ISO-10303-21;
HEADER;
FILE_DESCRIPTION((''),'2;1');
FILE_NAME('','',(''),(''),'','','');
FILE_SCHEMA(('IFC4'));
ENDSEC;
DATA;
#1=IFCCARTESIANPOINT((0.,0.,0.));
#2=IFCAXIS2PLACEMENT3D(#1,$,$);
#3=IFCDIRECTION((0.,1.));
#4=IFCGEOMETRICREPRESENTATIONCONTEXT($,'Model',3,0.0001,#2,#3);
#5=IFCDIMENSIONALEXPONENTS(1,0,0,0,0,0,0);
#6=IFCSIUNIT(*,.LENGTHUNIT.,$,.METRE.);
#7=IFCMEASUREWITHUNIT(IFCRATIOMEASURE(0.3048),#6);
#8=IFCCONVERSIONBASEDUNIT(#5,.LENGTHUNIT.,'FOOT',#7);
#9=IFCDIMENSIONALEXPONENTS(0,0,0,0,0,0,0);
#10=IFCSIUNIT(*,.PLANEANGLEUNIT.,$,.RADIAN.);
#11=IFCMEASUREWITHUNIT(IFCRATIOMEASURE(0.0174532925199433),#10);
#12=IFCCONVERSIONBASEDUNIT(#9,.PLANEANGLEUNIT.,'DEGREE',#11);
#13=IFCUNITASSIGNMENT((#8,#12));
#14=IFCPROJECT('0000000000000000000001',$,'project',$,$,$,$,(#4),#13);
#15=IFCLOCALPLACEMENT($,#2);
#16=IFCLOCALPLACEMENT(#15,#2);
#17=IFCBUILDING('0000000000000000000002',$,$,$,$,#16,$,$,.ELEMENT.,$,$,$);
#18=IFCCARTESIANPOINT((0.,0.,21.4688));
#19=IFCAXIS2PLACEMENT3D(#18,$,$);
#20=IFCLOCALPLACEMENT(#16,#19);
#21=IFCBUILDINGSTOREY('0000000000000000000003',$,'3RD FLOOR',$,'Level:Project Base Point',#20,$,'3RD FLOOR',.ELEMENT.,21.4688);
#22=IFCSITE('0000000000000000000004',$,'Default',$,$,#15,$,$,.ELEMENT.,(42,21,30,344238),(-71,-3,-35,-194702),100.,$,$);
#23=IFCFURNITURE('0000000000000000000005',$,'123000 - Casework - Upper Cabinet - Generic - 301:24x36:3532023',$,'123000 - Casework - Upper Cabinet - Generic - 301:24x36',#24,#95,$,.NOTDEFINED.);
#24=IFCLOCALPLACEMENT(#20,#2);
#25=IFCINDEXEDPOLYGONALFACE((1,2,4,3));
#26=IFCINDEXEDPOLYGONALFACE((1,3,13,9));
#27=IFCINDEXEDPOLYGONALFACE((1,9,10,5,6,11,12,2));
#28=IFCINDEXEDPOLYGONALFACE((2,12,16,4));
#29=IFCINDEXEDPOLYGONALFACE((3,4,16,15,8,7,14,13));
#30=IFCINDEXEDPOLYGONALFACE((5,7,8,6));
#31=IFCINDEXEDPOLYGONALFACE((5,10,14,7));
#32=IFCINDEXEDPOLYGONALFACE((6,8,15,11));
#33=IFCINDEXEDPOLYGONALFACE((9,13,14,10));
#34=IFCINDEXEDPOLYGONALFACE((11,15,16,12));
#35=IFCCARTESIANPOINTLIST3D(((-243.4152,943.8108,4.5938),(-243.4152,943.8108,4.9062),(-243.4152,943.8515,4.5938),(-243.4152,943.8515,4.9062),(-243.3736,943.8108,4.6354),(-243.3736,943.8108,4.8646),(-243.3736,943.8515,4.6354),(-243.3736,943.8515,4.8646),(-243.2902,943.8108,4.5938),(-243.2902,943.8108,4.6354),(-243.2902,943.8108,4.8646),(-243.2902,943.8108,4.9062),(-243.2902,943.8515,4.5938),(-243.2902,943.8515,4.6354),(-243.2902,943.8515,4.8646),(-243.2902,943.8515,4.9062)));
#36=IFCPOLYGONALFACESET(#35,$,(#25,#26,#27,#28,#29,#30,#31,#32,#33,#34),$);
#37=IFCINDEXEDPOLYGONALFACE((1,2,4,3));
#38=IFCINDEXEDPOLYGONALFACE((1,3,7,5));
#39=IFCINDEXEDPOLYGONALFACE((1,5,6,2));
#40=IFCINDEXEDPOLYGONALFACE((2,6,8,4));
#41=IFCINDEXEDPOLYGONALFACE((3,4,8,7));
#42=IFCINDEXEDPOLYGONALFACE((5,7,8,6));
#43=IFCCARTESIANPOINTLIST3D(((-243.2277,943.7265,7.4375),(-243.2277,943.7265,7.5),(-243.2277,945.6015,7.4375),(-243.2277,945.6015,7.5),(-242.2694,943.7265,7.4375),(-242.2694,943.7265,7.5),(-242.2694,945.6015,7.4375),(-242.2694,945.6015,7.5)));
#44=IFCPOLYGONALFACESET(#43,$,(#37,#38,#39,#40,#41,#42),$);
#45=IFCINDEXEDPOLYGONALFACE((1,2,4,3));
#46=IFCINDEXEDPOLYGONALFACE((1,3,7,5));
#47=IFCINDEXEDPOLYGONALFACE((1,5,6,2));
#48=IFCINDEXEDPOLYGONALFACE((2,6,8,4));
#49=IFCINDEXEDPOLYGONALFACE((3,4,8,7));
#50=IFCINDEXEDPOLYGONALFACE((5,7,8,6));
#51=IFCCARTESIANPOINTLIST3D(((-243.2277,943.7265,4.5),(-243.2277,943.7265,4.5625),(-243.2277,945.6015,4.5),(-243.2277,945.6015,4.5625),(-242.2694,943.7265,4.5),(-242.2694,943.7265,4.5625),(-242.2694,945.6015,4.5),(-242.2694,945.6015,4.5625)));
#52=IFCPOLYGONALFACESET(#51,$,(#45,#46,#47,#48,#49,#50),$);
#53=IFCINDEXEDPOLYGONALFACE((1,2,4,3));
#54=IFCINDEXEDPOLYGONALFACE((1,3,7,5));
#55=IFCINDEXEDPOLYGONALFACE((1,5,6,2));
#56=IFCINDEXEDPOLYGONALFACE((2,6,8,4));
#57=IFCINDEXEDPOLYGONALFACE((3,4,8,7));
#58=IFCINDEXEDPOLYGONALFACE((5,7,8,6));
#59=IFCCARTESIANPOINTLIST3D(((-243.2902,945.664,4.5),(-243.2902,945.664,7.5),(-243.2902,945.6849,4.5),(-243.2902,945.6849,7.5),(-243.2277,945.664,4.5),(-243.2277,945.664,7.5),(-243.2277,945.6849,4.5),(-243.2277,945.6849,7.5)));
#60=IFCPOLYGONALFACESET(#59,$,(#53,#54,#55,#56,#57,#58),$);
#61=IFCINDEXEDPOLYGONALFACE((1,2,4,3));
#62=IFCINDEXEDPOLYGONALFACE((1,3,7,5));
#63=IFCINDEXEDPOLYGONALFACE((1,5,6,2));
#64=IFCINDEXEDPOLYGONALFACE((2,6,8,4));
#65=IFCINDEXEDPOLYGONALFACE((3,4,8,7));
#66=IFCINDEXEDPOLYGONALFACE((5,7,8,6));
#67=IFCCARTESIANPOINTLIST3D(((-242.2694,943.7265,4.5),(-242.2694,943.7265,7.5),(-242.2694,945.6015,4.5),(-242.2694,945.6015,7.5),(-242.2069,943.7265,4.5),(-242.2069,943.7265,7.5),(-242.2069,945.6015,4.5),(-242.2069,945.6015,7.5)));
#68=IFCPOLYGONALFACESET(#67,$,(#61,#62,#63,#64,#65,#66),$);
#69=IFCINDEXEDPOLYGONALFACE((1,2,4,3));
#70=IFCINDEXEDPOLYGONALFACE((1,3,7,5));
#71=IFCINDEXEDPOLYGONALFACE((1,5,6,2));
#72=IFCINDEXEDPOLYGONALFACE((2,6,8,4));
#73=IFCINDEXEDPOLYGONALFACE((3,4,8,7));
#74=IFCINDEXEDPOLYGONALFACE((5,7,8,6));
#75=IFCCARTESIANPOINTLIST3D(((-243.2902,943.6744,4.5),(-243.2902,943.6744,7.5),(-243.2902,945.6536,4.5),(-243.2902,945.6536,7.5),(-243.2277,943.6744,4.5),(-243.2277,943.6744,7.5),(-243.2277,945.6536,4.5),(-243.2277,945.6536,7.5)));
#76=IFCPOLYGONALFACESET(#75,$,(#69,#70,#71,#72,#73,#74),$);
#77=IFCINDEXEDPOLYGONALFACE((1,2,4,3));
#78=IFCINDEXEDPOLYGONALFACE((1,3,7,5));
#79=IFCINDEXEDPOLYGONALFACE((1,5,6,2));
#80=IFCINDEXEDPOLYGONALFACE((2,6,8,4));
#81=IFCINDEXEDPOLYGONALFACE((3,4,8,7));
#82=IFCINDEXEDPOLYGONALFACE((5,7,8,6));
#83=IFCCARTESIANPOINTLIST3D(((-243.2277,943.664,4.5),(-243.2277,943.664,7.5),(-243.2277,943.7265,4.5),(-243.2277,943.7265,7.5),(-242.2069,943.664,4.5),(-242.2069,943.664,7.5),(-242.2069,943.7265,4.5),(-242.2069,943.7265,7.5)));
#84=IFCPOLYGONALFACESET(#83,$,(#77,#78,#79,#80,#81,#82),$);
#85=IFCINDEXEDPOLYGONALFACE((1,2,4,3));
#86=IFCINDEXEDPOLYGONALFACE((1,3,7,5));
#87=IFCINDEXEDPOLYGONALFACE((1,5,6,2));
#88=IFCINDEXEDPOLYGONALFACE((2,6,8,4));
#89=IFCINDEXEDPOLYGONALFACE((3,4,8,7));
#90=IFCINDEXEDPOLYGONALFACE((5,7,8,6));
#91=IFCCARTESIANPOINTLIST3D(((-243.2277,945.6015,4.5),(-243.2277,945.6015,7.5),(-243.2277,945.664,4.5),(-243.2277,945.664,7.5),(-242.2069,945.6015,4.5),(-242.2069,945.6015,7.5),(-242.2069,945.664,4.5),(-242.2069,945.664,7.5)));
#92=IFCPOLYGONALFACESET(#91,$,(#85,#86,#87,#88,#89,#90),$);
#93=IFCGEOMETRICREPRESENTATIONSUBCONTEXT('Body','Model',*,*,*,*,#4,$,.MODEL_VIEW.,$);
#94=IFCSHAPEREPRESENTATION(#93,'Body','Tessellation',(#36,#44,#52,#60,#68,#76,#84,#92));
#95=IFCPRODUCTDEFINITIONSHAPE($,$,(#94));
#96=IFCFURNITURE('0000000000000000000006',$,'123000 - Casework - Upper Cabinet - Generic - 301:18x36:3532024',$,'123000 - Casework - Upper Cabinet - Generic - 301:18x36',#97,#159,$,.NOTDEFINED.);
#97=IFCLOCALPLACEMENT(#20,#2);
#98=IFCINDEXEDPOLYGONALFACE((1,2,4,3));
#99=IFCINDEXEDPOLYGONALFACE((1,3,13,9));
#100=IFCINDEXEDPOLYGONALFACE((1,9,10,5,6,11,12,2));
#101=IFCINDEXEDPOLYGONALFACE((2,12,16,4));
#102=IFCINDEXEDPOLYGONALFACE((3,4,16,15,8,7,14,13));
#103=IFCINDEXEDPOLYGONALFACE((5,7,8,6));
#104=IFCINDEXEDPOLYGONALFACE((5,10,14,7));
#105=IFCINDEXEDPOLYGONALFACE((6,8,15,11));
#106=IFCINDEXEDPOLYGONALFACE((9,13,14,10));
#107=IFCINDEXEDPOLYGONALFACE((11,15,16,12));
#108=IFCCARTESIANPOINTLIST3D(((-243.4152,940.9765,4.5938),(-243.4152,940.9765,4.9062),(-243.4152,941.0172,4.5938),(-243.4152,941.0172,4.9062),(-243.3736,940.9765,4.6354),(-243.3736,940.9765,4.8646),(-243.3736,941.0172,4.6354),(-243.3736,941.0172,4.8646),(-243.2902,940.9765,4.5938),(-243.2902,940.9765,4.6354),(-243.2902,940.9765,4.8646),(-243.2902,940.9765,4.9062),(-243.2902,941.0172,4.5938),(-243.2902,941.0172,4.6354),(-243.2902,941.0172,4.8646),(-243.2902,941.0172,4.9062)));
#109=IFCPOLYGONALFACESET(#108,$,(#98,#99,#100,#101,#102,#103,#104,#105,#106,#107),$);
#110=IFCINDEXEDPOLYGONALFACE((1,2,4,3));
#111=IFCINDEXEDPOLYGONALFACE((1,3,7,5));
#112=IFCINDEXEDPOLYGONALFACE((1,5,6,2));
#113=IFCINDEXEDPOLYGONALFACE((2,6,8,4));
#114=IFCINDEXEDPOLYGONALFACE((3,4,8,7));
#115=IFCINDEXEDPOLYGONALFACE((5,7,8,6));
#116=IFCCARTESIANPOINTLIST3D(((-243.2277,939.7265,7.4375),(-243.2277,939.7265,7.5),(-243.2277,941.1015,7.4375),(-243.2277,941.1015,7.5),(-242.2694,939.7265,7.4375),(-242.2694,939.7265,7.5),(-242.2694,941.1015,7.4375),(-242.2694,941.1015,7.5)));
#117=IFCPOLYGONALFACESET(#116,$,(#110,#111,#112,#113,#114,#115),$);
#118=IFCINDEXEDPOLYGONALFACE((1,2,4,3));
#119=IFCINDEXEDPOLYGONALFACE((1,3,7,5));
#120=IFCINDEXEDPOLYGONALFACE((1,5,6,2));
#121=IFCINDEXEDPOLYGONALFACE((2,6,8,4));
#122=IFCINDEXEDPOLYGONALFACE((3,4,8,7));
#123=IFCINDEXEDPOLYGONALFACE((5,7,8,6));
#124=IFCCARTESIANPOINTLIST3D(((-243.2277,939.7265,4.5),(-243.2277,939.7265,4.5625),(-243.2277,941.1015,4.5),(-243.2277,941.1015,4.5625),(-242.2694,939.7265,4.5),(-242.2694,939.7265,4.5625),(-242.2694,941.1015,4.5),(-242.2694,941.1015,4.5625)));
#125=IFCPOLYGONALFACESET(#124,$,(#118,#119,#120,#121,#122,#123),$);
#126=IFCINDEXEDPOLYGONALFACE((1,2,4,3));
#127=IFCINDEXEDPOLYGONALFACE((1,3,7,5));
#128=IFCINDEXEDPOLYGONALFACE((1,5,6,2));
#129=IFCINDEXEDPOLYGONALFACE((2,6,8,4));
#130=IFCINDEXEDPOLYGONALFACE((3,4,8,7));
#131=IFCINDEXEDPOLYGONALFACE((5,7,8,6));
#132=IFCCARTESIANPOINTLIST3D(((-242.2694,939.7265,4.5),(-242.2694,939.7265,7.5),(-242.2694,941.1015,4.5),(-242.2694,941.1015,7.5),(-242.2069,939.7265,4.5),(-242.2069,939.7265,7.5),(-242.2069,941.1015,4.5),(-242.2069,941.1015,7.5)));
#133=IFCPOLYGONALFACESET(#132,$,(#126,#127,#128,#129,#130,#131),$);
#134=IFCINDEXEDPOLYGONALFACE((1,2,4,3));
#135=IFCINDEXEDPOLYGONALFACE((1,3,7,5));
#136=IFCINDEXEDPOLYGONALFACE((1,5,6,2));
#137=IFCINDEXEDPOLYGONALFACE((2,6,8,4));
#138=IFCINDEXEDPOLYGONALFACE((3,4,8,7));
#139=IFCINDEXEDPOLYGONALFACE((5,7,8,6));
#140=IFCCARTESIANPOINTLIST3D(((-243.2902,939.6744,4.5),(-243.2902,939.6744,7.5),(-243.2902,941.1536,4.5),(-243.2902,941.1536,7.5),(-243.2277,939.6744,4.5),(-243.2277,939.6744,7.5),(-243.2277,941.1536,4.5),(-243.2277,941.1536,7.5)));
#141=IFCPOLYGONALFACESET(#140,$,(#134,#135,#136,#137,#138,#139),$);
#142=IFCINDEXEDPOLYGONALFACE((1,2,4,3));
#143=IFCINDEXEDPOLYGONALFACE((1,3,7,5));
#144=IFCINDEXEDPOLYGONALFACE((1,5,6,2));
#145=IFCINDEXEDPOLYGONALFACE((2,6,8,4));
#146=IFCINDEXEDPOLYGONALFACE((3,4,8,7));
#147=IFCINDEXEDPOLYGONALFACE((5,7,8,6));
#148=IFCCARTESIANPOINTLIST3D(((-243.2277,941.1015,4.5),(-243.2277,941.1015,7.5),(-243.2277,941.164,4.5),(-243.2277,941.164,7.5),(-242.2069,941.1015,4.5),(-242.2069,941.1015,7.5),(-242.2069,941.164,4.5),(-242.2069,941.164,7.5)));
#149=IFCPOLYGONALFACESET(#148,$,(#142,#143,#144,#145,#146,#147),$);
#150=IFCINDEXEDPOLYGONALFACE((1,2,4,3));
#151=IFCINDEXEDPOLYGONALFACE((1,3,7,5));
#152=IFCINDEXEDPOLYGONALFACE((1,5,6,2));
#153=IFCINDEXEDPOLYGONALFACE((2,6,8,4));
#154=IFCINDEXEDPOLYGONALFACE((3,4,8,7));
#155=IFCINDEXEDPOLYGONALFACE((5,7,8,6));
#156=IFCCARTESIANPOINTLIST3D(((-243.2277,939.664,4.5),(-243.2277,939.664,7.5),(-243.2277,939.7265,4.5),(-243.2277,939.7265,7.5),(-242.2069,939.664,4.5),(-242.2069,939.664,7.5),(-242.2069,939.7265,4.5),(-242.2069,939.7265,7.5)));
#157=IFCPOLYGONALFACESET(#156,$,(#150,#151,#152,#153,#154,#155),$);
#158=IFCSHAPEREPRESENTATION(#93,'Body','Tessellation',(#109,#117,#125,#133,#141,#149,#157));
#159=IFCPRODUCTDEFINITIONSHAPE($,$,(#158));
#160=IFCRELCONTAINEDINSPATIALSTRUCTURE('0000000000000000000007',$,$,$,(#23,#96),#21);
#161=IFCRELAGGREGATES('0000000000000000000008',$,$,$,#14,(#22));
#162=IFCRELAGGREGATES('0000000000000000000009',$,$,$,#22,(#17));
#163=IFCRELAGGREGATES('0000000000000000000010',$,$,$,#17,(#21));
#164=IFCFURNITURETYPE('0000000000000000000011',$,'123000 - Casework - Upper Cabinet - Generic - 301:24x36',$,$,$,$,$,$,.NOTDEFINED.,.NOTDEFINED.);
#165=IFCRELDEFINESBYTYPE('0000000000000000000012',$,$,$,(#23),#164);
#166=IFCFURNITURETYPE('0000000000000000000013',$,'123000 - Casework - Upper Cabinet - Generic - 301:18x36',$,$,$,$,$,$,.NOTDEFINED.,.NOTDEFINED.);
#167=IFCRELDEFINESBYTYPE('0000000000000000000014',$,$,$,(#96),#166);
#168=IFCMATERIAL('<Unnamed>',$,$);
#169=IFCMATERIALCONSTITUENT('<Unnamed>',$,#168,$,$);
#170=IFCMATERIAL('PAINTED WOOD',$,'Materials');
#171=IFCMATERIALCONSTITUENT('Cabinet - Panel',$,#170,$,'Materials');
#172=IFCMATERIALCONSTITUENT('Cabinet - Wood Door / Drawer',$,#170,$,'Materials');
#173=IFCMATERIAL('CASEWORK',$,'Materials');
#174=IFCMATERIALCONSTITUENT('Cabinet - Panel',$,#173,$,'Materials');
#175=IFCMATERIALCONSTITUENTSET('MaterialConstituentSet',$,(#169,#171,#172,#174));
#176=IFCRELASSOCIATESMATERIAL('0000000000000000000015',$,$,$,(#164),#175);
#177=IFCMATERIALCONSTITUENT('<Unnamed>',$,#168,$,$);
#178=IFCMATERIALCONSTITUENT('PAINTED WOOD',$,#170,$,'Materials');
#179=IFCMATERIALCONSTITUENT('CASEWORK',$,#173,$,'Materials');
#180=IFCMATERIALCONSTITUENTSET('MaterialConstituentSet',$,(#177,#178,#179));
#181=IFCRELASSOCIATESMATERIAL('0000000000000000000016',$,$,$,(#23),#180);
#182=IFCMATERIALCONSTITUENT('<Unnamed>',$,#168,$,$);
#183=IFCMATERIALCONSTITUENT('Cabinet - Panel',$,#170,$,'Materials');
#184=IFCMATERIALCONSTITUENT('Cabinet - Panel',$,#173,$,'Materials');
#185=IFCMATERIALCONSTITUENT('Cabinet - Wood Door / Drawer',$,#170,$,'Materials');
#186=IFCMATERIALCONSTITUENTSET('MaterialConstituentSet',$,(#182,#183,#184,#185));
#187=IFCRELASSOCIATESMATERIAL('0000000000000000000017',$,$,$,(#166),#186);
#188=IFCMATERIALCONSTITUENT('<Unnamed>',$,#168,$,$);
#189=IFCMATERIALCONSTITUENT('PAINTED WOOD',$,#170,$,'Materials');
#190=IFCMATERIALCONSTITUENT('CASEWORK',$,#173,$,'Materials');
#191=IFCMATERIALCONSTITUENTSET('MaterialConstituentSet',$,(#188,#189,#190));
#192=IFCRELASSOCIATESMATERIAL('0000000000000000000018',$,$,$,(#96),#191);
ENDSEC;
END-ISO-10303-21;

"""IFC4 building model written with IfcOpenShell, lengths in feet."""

from ifc_helpers import new_model, entity, si_unit, converted_unit, direction, frame, frame_2d, origin, origin_2d_with_axis, place, context, subcontext, project, spatial, polyline, rectangle, outline, extrude, source, transform, mapped, material, constituent, constituent_set, type_object, type_shapes, element, save


model = new_model("IFC4")

# Units and contexts
model_context = context("Model", 3, precision=0.0001, world=origin(), true_north=direction((0.0, 1.0)))
body_context = subcontext(model_context, "Body", "Model", "MODEL_VIEW")
ifc_project = project(units=[converted_unit("LENGTHUNIT", "FOOT", entity("IfcRatioMeasure", 0.3048), si_unit("LENGTHUNIT", "METRE"), dimensions=[1, 0, 0, 0, 0, 0, 0]), converted_unit("PLANEANGLEUNIT", "DEGREE", entity("IfcRatioMeasure", 0.0174532925199433), si_unit("PLANEANGLEUNIT", "RADIAN"), dimensions=[0, 0, 0, 0, 0, 0, 0])], contexts=[model_context])

# Site, building, storey
site_placement = place(None, origin())
site = spatial("IfcSite", under=ifc_project, at=site_placement, Name="Default", CompositionType="ELEMENT", RefLatitude=(42, 21, 30, 344238), RefLongitude=(-71, -3, -35, -194702), RefElevation=100.0)
building_placement = place(site_placement, origin())
building = spatial("IfcBuilding", under=site, at=building_placement, CompositionType="ELEMENT")
storey_placement = place(building_placement, frame((0.0, 0.0, 21.4688)))
storey = spatial("IfcBuildingStorey", under=building, at=storey_placement, Name="3RD FLOOR", ObjectType="Level:Project Base Point", LongName="3RD FLOOR", CompositionType="ELEMENT", Elevation=21.4688)

# Furniture
ifc_material_1 = material(Name="CASEWORK", Category="Materials")
ifc_material_2 = material(Name="<Unnamed>")
ifc_material_3 = material(Name="PAINTED WOOD", Category="Materials")
ifc_constituent_1 = constituent(ifc_material_2, Name="<Unnamed>")
ifc_constituent_2 = constituent(ifc_material_3, Name="PAINTED WOOD", Category="Materials")
ifc_constituent_3 = constituent(ifc_material_1, Name="CASEWORK", Category="Materials")
ifc_constituent_set_1 = constituent_set(constituents=[ifc_constituent_1, ifc_constituent_2, ifc_constituent_3], Name="MaterialConstituentSet")
ifc_constituent_4 = constituent(ifc_material_2, Name="<Unnamed>")
ifc_constituent_5 = constituent(ifc_material_3, Name="Cabinet - Panel", Category="Materials")
ifc_constituent_6 = constituent(ifc_material_3, Name="Cabinet - Wood Door / Drawer", Category="Materials")
ifc_constituent_7 = constituent(ifc_material_1, Name="Cabinet - Panel", Category="Materials")
ifc_constituent_set_2 = constituent_set(constituents=[ifc_constituent_4, ifc_constituent_5, ifc_constituent_6, ifc_constituent_7], Name="MaterialConstituentSet")
furniture_type_1 = type_object("IfcFurnitureType", Name="123000 - Casework - Upper Cabinet - Generic - 301:24x36", AssemblyPlace="NOTDEFINED", PredefinedType="NOTDEFINED", material=ifc_constituent_set_2)
shared_shape_1 = source(origin(), body_context, "Body", "SweptSolid", [
    extrude(outline(polyline([(-0.0521, -0.1146), (-0.0521, -0.1562), (0.0729, -0.1562), (0.0729, 0.1562), (-0.0521, 0.1562), (-0.0521, 0.1146), (0.0313, 0.1146), (0.0313, -0.1146), (-0.0521, -0.1146)])), frame((0.1468, 1.1354, 0.25), z_axis=(-1.0, 0.0, 0.0), x_axis=(0.0, 1.0, 0.0)), (0.0, 0.0, -1.0), 0.0407),
    extrude(rectangle(XDim=0.9583, YDim=1.875, at=frame_2d((0.0, 0.0), x_axis=(1.0, 0.0))), frame((1.0, 0.5417, 2.9375), z_axis=(0.0, 0.0, 1.0), x_axis=(0.0, 1.0, 0.0)), (0.0, 0.0, 1.0), 0.0625),
    extrude(rectangle(XDim=0.9583, YDim=1.875, at=frame_2d((0.0, 0.0), x_axis=(1.0, 0.0))), frame((1.0, 0.5417, 0.0), z_axis=(0.0, 0.0, 1.0), x_axis=(0.0, 1.0, 0.0)), (0.0, 0.0, 1.0), 0.0625),
    extrude(rectangle(XDim=0.0208, YDim=0.0625, at=frame_2d((0.0, 0.0), x_axis=(1.0, 0.0))), frame((2.0104, 1.0521, 0.0)), (0.0, 0.0, 1.0), 3.0),
    extrude(rectangle(XDim=1.875, YDim=0.0625, at=origin_2d_with_axis()), frame((1.0, 0.0313, 0.0), z_axis=(0.0, 0.0, 1.0), x_axis=(-1.0, 0.0, 0.0)), (0.0, 0.0, 1.0), 3.0),
    extrude(rectangle(XDim=1.9792, YDim=0.0625, at=frame_2d((0.0, 0.0), x_axis=(1.0, 0.0))), frame((1.0, 1.0521, 0.0)), (0.0, 0.0, 1.0), 3.0),
    extrude(rectangle(XDim=1.0208, YDim=0.0625, at=origin_2d_with_axis()), frame((0.0312, 0.5104, 0.0), z_axis=(0.0, 0.0, 1.0), x_axis=(0.0, 1.0, 0.0)), (0.0, 0.0, 1.0), 3.0),
    extrude(rectangle(XDim=1.0208, YDim=0.0625, at=origin_2d_with_axis()), frame((1.9688, 0.5104, 0.0), z_axis=(0.0, 0.0, 1.0), x_axis=(0.0, 1.0, 0.0)), (0.0, 0.0, 1.0), 3.0),
])
type_shapes(furniture_type_1, [shared_shape_1])
furniture_1_placement = place(storey_placement, frame((-242.2069, 943.664, 4.5), z_axis=(0.0, 0.0, 1.0), x_axis=(0.0, 1.0, 0.0)))
element("IfcFurniture", 1, at=furniture_1_placement, inside=storey, type_object=furniture_type_1, material=ifc_constituent_set_1, Name="123000 - Casework - Upper Cabinet - Generic - 301:24x36:3532023", ObjectType="123000 - Casework - Upper Cabinet - Generic - 301:24x36", PredefinedType="NOTDEFINED", context=body_context, shape_type="MappedRepresentation", body=[
    mapped(shared_shape_1, transform((0.0, 0.0, 0.0), scale=1.0)),
])
ifc_constituent_8 = constituent(ifc_material_2, Name="<Unnamed>")
ifc_constituent_9 = constituent(ifc_material_3, Name="PAINTED WOOD", Category="Materials")
ifc_constituent_10 = constituent(ifc_material_1, Name="CASEWORK", Category="Materials")
ifc_constituent_set_3 = constituent_set(constituents=[ifc_constituent_8, ifc_constituent_9, ifc_constituent_10], Name="MaterialConstituentSet")
ifc_constituent_11 = constituent(ifc_material_2, Name="<Unnamed>")
ifc_constituent_12 = constituent(ifc_material_3, Name="Cabinet - Panel", Category="Materials")
ifc_constituent_13 = constituent(ifc_material_1, Name="Cabinet - Panel", Category="Materials")
ifc_constituent_14 = constituent(ifc_material_3, Name="Cabinet - Wood Door / Drawer", Category="Materials")
ifc_constituent_set_4 = constituent_set(constituents=[ifc_constituent_11, ifc_constituent_12, ifc_constituent_13, ifc_constituent_14], Name="MaterialConstituentSet")
furniture_type_2 = type_object("IfcFurnitureType", Name="123000 - Casework - Upper Cabinet - Generic - 301:18x36", AssemblyPlace="NOTDEFINED", PredefinedType="NOTDEFINED", material=ifc_constituent_set_4)
shared_shape_2 = source(origin(), body_context, "Body", "SweptSolid", [
    extrude(outline(polyline([(0.1146, -0.0521), (0.1562, -0.0521), (0.1562, 0.0729), (-0.1562, 0.0729), (-0.1562, -0.0521), (-0.1146, -0.0521), (-0.1146, 0.0313), (0.1146, 0.0313), (0.1146, -0.0521)])), frame((0.1468, 0.0729, 0.25), z_axis=(1.0, 0.0, 0.0), x_axis=(0.0, 0.0, 1.0)), (0.0, 0.0, 1.0), 0.0407),
    extrude(rectangle(XDim=1.375, YDim=0.9583, at=frame_2d((0.0, 0.0), x_axis=(1.0, 0.0))), frame((0.75, 0.6666, 2.9375), z_axis=(0.0, 0.0, 1.0), x_axis=(-1.0, 0.0, 0.0)), (0.0, 0.0, 1.0), 0.0625),
    extrude(rectangle(XDim=1.375, YDim=0.9583, at=frame_2d((0.0, 0.0), x_axis=(1.0, 0.0))), frame((0.75, 0.6666, 0.0), z_axis=(0.0, 0.0, 1.0), x_axis=(-1.0, 0.0, 0.0)), (0.0, 0.0, 1.0), 0.0625),
    extrude(rectangle(XDim=0.0625, YDim=1.375, at=origin_2d_with_axis()), frame((0.75, 1.177, 0.0), z_axis=(0.0, 0.0, 1.0), x_axis=(0.0, 1.0, 0.0)), (0.0, 0.0, 1.0), 3.0),
    extrude(rectangle(XDim=0.0625, YDim=1.4792, at=origin_2d_with_axis()), frame((0.75, 0.1562, 0.0), z_axis=(0.0, 0.0, 1.0), x_axis=(0.0, -1.0, 0.0)), (0.0, 0.0, 1.0), 3.0),
    extrude(rectangle(XDim=0.0625, YDim=1.0208, at=origin_2d_with_axis()), frame((0.0312, 0.6979, 0.0), z_axis=(0.0, 0.0, 1.0), x_axis=(-1.0, 0.0, 0.0)), (0.0, 0.0, 1.0), 3.0),
    extrude(rectangle(XDim=0.0625, YDim=1.0208, at=origin_2d_with_axis()), frame((1.4688, 0.6979, 0.0), z_axis=(0.0, 0.0, 1.0), x_axis=(-1.0, 0.0, 0.0)), (0.0, 0.0, 1.0), 3.0),
])
type_shapes(furniture_type_2, [shared_shape_2])
furniture_2_placement = place(storey_placement, frame((-243.4152, 941.164, 4.5), z_axis=(0.0, 0.0, 1.0), x_axis=(0.0, -1.0, 0.0)))
element("IfcFurniture", 2, at=furniture_2_placement, inside=storey, type_object=furniture_type_2, material=ifc_constituent_set_3, Name="123000 - Casework - Upper Cabinet - Generic - 301:18x36:3532024", ObjectType="123000 - Casework - Upper Cabinet - Generic - 301:18x36", PredefinedType="NOTDEFINED", context=body_context, shape_type="MappedRepresentation", body=[
    mapped(shared_shape_2, transform((0.0, 0.0, 0.0), scale=1.0)),
])

save(model, "model.ifc")
